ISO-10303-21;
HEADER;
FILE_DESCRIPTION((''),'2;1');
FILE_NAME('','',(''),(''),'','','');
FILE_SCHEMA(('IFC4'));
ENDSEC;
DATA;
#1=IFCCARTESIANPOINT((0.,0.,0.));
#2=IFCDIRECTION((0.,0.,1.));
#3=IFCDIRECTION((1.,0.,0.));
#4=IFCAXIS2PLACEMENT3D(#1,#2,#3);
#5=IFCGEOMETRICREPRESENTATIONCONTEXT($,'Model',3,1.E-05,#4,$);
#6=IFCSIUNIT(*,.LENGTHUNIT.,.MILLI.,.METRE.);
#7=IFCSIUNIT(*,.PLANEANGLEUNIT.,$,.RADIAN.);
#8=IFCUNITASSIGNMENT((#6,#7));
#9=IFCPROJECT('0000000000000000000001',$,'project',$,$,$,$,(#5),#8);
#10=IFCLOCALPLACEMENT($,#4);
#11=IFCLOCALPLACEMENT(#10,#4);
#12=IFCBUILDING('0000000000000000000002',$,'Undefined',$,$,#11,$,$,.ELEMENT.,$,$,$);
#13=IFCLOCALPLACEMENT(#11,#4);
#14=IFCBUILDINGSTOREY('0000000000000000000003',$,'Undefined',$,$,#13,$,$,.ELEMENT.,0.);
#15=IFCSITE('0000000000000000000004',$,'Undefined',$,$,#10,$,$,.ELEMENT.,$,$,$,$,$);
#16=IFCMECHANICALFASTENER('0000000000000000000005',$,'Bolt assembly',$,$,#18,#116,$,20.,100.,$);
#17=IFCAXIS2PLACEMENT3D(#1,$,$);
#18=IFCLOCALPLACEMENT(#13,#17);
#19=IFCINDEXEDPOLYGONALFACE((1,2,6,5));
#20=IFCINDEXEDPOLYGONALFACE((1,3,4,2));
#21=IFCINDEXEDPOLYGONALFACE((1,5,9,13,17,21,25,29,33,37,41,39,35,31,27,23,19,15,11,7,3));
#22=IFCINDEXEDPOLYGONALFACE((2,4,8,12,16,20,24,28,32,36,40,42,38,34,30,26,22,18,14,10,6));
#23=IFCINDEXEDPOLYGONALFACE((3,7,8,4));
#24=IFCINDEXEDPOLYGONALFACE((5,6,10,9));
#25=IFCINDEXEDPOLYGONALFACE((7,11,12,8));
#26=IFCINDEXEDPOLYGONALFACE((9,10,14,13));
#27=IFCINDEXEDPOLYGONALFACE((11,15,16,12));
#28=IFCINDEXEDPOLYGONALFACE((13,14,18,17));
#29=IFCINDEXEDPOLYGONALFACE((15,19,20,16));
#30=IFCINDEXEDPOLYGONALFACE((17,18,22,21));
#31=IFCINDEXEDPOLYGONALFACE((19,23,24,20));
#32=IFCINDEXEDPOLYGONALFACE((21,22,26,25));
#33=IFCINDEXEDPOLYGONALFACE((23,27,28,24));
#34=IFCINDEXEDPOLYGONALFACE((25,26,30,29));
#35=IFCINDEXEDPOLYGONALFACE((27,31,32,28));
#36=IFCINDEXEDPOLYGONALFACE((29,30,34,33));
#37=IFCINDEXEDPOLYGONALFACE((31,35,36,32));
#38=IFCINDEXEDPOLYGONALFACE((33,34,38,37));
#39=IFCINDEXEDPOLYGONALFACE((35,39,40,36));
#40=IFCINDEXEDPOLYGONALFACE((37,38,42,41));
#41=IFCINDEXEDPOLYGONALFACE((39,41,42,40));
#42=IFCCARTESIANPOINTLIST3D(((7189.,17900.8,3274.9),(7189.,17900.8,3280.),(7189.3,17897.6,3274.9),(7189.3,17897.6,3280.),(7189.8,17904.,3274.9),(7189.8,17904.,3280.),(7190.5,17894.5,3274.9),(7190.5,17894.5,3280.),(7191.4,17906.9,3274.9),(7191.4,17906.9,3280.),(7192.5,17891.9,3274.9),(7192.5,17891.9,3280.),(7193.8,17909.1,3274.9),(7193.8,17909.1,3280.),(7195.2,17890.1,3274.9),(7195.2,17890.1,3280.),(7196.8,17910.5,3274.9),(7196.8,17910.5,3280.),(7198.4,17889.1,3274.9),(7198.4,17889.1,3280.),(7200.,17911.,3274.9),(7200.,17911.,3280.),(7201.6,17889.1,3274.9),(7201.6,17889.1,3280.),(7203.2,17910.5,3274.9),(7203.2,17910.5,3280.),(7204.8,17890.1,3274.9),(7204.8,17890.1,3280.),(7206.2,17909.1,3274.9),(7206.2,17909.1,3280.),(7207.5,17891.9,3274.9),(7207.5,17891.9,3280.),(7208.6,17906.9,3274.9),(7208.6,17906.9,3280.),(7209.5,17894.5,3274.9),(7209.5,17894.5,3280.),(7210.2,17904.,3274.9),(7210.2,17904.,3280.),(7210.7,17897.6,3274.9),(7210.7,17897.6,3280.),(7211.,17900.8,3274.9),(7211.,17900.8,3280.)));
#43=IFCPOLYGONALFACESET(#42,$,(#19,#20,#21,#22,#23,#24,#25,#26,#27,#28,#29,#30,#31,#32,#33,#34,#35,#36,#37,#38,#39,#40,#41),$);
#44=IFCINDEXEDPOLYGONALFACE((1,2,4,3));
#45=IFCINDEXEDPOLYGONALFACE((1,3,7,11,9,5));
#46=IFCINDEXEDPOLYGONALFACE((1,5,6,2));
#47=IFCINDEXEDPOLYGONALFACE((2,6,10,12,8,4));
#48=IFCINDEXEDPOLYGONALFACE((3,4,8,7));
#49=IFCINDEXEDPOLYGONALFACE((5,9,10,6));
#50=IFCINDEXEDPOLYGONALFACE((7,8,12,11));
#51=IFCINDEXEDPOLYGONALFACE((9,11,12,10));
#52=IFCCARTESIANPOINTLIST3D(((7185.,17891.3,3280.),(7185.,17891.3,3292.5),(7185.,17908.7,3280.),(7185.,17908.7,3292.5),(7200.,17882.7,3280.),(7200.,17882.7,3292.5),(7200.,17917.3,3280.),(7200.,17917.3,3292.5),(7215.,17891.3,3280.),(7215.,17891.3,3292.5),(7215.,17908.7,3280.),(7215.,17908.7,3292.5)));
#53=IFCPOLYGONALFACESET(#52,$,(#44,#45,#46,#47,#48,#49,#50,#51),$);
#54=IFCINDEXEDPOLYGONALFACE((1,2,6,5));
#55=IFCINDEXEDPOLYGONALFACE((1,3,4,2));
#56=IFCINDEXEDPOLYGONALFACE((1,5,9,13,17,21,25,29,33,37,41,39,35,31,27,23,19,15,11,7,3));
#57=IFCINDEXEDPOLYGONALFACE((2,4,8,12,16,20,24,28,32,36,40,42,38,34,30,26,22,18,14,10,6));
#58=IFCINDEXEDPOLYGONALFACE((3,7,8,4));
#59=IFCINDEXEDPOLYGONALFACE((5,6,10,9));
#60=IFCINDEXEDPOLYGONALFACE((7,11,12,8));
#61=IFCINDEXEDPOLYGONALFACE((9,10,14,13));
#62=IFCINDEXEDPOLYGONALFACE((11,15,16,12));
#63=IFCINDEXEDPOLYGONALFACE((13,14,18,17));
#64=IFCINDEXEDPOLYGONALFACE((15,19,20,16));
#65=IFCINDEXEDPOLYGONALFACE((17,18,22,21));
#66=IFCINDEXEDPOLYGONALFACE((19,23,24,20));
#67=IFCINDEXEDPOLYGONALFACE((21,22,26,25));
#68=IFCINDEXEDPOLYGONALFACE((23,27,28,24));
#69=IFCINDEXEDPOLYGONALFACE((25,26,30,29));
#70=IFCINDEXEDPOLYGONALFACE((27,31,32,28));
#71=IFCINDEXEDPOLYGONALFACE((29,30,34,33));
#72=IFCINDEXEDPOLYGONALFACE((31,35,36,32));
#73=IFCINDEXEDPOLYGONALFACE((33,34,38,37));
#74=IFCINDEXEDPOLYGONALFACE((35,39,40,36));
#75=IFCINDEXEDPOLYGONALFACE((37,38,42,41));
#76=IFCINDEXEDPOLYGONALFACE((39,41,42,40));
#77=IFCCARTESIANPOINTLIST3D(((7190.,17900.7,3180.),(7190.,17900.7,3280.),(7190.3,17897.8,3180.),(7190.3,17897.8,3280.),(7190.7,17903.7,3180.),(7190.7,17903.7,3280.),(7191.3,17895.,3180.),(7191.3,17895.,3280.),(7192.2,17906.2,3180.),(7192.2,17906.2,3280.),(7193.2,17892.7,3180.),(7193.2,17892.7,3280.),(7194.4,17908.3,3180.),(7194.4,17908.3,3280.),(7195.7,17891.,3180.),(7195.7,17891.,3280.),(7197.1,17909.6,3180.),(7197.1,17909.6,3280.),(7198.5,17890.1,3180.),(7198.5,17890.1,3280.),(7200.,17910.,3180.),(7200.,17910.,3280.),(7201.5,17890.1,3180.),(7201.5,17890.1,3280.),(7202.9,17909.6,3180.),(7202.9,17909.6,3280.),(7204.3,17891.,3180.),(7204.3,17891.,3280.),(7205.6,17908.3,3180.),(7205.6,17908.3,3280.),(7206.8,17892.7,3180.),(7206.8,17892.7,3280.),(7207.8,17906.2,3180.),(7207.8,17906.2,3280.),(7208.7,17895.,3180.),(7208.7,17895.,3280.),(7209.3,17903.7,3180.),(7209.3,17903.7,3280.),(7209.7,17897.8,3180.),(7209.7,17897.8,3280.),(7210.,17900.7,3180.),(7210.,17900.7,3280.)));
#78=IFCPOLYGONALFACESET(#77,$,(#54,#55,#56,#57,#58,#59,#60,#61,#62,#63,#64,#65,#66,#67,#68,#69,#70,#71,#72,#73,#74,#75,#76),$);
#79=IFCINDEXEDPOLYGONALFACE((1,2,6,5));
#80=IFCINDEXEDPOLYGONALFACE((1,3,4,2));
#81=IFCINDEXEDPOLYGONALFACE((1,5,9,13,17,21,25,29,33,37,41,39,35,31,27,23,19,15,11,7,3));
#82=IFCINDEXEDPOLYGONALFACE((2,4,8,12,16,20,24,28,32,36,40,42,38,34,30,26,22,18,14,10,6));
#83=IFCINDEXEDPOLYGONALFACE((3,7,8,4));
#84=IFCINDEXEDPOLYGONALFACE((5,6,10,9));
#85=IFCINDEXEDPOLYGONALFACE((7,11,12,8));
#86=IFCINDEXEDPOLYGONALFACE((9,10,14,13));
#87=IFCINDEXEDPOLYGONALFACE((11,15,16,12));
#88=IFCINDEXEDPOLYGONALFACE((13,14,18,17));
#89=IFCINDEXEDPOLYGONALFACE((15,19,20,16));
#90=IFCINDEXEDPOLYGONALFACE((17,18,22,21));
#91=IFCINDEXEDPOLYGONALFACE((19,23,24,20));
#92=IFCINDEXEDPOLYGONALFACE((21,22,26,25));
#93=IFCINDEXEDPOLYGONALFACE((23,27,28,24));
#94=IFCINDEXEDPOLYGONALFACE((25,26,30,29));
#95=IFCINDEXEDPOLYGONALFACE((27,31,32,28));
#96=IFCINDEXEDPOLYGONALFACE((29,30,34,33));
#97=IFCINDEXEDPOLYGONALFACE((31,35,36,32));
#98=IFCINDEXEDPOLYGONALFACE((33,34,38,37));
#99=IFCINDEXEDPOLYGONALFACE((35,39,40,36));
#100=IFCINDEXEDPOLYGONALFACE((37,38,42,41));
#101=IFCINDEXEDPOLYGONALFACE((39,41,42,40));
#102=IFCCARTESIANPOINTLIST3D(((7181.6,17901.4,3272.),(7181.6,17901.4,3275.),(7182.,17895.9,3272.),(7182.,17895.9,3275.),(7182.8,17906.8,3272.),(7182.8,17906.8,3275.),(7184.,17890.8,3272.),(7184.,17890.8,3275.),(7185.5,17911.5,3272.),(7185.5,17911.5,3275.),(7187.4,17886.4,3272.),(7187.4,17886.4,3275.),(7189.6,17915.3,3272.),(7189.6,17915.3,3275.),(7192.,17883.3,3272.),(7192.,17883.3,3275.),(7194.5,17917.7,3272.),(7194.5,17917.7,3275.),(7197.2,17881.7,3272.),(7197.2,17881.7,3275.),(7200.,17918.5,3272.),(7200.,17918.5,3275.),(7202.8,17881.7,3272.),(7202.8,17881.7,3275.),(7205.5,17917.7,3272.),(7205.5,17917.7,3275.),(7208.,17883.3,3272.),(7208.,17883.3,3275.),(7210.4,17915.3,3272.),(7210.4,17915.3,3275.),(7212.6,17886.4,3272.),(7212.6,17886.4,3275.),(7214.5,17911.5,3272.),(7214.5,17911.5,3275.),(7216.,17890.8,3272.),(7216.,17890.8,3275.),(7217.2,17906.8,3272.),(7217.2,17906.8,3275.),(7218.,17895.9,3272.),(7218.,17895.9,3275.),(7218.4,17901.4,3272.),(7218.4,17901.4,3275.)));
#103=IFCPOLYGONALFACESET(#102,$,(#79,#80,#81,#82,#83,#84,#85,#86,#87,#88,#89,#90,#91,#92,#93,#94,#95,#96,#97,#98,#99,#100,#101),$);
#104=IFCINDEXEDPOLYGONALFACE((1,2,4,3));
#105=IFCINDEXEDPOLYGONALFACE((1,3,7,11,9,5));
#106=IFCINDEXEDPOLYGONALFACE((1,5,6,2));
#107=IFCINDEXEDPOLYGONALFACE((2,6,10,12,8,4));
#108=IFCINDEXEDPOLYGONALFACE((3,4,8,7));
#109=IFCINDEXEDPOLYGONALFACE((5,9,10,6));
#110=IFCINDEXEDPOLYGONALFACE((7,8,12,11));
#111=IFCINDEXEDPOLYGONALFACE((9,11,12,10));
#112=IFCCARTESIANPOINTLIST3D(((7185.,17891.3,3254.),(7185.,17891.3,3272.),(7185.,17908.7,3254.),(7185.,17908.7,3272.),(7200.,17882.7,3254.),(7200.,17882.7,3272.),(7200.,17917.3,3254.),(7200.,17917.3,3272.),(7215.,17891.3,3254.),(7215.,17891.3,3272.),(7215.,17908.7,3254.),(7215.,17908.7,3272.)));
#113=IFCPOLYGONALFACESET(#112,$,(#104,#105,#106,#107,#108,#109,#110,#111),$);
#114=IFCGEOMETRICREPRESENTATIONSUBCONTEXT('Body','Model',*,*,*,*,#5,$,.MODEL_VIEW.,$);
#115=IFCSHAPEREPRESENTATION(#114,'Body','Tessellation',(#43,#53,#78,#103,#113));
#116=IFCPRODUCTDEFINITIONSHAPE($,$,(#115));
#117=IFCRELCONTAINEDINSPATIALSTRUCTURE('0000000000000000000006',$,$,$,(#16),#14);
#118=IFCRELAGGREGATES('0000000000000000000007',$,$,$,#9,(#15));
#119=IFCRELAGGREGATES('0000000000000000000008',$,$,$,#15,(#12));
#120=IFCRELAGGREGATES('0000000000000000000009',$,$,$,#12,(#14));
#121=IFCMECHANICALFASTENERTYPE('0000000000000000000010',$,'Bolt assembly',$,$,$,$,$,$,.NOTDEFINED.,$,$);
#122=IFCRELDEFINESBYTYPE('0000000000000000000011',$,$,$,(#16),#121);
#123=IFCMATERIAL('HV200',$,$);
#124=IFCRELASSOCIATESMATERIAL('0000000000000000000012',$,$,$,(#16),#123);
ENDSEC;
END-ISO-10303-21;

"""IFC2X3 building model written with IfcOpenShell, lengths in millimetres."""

from ifc_helpers import new_model, si_unit, frame, origin_with_axes, origin_2d_with_axis, place, context, subcontext, project, spatial, polyline, circle, outline, extrude, source, transform, mapped, material, type_object, element, save


model = new_model("IFC2X3")

# Units and contexts
model_context = context("Model", 3, precision=1e-05, world=origin_with_axes())
body_context = subcontext(model_context, "Body", "Model", "MODEL_VIEW")
ifc_project = project(units=[si_unit("LENGTHUNIT", "METRE", prefix="MILLI"), si_unit("PLANEANGLEUNIT", "RADIAN")], contexts=[model_context])

# Site, building, storey
site_placement = place(None, origin_with_axes())
site = spatial("IfcSite", under=ifc_project, at=site_placement, Name="Undefined", CompositionType="ELEMENT")
building_placement = place(site_placement, origin_with_axes())
building = spatial("IfcBuilding", under=site, at=building_placement, Name="Undefined", CompositionType="ELEMENT")
storey_placement = place(building_placement, origin_with_axes())
storey = spatial("IfcBuildingStorey", under=building, at=storey_placement, Name="Undefined", CompositionType="ELEMENT", Elevation=0.0)

# Mechanical fastener
ifc_material_1 = material(Name="HV200")
mechanical_fastener_type = type_object("IfcMechanicalFastenerType", Name="Bolt assembly")
shared_shape_1 = source(origin_with_axes(), body_context, "Body", "SweptSolid", [
    extrude(circle(Radius=11.0, at=origin_2d_with_axis()), frame((0.0, 0.0, 0.0), z_axis=(0.0, 1.0, 0.0), x_axis=(1.0, 0.0, 0.0)), (0.0, 0.0, 1.0), 5.1),
    extrude(outline(polyline([(17.3, 0.0), (8.7, 15.0), (-8.7, 15.0), (-17.3, 0.0), (-8.7, -15.0), (8.7, -15.0), (17.3, 0.0)])), frame((0.0, -12.5, 0.0), z_axis=(0.0, 1.0, 0.0), x_axis=(1.0, 0.0, 0.0)), (0.0, 0.0, 1.0), 12.5),
    extrude(circle(Radius=10.0, at=origin_2d_with_axis()), frame((0.0, 0.0, 0.0), z_axis=(0.0, 1.0, 0.0), x_axis=(1.0, 0.0, 0.0)), (0.0, 0.0, 1.0), 100.0),
    extrude(circle(Radius=18.5, at=origin_2d_with_axis()), frame((0.0, 5.0, 0.0), z_axis=(0.0, 1.0, 0.0), x_axis=(1.0, 0.0, 0.0)), (0.0, 0.0, 1.0), 3.0),
    extrude(outline(polyline([(17.3, 0.0), (8.7, 15.0), (-8.7, 15.0), (-17.3, 0.0), (-8.7, -15.0), (8.7, -15.0), (17.3, 0.0)])), frame((0.0, 8.0, 0.0), z_axis=(0.0, 1.0, 0.0), x_axis=(1.0, 0.0, 0.0)), (0.0, 0.0, 1.0), 18.0),
])
mechanical_fastener_1_placement = place(storey_placement, frame((7200.0, 17900.0, 3280.0), z_axis=(-1.0, 0.0, 0.0), x_axis=(0.0, 1.0, 0.0)))
element("IfcMechanicalFastener", 1, at=mechanical_fastener_1_placement, inside=storey, type_object=mechanical_fastener_type, material=ifc_material_1, Name="Bolt assembly", NominalDiameter=20.0, NominalLength=100.0, context=body_context, shape_type="MappedRepresentation", body=[
    mapped(shared_shape_1, transform((0.0, 0.0, 0.0))),
])

save(model, "model.ifc")
